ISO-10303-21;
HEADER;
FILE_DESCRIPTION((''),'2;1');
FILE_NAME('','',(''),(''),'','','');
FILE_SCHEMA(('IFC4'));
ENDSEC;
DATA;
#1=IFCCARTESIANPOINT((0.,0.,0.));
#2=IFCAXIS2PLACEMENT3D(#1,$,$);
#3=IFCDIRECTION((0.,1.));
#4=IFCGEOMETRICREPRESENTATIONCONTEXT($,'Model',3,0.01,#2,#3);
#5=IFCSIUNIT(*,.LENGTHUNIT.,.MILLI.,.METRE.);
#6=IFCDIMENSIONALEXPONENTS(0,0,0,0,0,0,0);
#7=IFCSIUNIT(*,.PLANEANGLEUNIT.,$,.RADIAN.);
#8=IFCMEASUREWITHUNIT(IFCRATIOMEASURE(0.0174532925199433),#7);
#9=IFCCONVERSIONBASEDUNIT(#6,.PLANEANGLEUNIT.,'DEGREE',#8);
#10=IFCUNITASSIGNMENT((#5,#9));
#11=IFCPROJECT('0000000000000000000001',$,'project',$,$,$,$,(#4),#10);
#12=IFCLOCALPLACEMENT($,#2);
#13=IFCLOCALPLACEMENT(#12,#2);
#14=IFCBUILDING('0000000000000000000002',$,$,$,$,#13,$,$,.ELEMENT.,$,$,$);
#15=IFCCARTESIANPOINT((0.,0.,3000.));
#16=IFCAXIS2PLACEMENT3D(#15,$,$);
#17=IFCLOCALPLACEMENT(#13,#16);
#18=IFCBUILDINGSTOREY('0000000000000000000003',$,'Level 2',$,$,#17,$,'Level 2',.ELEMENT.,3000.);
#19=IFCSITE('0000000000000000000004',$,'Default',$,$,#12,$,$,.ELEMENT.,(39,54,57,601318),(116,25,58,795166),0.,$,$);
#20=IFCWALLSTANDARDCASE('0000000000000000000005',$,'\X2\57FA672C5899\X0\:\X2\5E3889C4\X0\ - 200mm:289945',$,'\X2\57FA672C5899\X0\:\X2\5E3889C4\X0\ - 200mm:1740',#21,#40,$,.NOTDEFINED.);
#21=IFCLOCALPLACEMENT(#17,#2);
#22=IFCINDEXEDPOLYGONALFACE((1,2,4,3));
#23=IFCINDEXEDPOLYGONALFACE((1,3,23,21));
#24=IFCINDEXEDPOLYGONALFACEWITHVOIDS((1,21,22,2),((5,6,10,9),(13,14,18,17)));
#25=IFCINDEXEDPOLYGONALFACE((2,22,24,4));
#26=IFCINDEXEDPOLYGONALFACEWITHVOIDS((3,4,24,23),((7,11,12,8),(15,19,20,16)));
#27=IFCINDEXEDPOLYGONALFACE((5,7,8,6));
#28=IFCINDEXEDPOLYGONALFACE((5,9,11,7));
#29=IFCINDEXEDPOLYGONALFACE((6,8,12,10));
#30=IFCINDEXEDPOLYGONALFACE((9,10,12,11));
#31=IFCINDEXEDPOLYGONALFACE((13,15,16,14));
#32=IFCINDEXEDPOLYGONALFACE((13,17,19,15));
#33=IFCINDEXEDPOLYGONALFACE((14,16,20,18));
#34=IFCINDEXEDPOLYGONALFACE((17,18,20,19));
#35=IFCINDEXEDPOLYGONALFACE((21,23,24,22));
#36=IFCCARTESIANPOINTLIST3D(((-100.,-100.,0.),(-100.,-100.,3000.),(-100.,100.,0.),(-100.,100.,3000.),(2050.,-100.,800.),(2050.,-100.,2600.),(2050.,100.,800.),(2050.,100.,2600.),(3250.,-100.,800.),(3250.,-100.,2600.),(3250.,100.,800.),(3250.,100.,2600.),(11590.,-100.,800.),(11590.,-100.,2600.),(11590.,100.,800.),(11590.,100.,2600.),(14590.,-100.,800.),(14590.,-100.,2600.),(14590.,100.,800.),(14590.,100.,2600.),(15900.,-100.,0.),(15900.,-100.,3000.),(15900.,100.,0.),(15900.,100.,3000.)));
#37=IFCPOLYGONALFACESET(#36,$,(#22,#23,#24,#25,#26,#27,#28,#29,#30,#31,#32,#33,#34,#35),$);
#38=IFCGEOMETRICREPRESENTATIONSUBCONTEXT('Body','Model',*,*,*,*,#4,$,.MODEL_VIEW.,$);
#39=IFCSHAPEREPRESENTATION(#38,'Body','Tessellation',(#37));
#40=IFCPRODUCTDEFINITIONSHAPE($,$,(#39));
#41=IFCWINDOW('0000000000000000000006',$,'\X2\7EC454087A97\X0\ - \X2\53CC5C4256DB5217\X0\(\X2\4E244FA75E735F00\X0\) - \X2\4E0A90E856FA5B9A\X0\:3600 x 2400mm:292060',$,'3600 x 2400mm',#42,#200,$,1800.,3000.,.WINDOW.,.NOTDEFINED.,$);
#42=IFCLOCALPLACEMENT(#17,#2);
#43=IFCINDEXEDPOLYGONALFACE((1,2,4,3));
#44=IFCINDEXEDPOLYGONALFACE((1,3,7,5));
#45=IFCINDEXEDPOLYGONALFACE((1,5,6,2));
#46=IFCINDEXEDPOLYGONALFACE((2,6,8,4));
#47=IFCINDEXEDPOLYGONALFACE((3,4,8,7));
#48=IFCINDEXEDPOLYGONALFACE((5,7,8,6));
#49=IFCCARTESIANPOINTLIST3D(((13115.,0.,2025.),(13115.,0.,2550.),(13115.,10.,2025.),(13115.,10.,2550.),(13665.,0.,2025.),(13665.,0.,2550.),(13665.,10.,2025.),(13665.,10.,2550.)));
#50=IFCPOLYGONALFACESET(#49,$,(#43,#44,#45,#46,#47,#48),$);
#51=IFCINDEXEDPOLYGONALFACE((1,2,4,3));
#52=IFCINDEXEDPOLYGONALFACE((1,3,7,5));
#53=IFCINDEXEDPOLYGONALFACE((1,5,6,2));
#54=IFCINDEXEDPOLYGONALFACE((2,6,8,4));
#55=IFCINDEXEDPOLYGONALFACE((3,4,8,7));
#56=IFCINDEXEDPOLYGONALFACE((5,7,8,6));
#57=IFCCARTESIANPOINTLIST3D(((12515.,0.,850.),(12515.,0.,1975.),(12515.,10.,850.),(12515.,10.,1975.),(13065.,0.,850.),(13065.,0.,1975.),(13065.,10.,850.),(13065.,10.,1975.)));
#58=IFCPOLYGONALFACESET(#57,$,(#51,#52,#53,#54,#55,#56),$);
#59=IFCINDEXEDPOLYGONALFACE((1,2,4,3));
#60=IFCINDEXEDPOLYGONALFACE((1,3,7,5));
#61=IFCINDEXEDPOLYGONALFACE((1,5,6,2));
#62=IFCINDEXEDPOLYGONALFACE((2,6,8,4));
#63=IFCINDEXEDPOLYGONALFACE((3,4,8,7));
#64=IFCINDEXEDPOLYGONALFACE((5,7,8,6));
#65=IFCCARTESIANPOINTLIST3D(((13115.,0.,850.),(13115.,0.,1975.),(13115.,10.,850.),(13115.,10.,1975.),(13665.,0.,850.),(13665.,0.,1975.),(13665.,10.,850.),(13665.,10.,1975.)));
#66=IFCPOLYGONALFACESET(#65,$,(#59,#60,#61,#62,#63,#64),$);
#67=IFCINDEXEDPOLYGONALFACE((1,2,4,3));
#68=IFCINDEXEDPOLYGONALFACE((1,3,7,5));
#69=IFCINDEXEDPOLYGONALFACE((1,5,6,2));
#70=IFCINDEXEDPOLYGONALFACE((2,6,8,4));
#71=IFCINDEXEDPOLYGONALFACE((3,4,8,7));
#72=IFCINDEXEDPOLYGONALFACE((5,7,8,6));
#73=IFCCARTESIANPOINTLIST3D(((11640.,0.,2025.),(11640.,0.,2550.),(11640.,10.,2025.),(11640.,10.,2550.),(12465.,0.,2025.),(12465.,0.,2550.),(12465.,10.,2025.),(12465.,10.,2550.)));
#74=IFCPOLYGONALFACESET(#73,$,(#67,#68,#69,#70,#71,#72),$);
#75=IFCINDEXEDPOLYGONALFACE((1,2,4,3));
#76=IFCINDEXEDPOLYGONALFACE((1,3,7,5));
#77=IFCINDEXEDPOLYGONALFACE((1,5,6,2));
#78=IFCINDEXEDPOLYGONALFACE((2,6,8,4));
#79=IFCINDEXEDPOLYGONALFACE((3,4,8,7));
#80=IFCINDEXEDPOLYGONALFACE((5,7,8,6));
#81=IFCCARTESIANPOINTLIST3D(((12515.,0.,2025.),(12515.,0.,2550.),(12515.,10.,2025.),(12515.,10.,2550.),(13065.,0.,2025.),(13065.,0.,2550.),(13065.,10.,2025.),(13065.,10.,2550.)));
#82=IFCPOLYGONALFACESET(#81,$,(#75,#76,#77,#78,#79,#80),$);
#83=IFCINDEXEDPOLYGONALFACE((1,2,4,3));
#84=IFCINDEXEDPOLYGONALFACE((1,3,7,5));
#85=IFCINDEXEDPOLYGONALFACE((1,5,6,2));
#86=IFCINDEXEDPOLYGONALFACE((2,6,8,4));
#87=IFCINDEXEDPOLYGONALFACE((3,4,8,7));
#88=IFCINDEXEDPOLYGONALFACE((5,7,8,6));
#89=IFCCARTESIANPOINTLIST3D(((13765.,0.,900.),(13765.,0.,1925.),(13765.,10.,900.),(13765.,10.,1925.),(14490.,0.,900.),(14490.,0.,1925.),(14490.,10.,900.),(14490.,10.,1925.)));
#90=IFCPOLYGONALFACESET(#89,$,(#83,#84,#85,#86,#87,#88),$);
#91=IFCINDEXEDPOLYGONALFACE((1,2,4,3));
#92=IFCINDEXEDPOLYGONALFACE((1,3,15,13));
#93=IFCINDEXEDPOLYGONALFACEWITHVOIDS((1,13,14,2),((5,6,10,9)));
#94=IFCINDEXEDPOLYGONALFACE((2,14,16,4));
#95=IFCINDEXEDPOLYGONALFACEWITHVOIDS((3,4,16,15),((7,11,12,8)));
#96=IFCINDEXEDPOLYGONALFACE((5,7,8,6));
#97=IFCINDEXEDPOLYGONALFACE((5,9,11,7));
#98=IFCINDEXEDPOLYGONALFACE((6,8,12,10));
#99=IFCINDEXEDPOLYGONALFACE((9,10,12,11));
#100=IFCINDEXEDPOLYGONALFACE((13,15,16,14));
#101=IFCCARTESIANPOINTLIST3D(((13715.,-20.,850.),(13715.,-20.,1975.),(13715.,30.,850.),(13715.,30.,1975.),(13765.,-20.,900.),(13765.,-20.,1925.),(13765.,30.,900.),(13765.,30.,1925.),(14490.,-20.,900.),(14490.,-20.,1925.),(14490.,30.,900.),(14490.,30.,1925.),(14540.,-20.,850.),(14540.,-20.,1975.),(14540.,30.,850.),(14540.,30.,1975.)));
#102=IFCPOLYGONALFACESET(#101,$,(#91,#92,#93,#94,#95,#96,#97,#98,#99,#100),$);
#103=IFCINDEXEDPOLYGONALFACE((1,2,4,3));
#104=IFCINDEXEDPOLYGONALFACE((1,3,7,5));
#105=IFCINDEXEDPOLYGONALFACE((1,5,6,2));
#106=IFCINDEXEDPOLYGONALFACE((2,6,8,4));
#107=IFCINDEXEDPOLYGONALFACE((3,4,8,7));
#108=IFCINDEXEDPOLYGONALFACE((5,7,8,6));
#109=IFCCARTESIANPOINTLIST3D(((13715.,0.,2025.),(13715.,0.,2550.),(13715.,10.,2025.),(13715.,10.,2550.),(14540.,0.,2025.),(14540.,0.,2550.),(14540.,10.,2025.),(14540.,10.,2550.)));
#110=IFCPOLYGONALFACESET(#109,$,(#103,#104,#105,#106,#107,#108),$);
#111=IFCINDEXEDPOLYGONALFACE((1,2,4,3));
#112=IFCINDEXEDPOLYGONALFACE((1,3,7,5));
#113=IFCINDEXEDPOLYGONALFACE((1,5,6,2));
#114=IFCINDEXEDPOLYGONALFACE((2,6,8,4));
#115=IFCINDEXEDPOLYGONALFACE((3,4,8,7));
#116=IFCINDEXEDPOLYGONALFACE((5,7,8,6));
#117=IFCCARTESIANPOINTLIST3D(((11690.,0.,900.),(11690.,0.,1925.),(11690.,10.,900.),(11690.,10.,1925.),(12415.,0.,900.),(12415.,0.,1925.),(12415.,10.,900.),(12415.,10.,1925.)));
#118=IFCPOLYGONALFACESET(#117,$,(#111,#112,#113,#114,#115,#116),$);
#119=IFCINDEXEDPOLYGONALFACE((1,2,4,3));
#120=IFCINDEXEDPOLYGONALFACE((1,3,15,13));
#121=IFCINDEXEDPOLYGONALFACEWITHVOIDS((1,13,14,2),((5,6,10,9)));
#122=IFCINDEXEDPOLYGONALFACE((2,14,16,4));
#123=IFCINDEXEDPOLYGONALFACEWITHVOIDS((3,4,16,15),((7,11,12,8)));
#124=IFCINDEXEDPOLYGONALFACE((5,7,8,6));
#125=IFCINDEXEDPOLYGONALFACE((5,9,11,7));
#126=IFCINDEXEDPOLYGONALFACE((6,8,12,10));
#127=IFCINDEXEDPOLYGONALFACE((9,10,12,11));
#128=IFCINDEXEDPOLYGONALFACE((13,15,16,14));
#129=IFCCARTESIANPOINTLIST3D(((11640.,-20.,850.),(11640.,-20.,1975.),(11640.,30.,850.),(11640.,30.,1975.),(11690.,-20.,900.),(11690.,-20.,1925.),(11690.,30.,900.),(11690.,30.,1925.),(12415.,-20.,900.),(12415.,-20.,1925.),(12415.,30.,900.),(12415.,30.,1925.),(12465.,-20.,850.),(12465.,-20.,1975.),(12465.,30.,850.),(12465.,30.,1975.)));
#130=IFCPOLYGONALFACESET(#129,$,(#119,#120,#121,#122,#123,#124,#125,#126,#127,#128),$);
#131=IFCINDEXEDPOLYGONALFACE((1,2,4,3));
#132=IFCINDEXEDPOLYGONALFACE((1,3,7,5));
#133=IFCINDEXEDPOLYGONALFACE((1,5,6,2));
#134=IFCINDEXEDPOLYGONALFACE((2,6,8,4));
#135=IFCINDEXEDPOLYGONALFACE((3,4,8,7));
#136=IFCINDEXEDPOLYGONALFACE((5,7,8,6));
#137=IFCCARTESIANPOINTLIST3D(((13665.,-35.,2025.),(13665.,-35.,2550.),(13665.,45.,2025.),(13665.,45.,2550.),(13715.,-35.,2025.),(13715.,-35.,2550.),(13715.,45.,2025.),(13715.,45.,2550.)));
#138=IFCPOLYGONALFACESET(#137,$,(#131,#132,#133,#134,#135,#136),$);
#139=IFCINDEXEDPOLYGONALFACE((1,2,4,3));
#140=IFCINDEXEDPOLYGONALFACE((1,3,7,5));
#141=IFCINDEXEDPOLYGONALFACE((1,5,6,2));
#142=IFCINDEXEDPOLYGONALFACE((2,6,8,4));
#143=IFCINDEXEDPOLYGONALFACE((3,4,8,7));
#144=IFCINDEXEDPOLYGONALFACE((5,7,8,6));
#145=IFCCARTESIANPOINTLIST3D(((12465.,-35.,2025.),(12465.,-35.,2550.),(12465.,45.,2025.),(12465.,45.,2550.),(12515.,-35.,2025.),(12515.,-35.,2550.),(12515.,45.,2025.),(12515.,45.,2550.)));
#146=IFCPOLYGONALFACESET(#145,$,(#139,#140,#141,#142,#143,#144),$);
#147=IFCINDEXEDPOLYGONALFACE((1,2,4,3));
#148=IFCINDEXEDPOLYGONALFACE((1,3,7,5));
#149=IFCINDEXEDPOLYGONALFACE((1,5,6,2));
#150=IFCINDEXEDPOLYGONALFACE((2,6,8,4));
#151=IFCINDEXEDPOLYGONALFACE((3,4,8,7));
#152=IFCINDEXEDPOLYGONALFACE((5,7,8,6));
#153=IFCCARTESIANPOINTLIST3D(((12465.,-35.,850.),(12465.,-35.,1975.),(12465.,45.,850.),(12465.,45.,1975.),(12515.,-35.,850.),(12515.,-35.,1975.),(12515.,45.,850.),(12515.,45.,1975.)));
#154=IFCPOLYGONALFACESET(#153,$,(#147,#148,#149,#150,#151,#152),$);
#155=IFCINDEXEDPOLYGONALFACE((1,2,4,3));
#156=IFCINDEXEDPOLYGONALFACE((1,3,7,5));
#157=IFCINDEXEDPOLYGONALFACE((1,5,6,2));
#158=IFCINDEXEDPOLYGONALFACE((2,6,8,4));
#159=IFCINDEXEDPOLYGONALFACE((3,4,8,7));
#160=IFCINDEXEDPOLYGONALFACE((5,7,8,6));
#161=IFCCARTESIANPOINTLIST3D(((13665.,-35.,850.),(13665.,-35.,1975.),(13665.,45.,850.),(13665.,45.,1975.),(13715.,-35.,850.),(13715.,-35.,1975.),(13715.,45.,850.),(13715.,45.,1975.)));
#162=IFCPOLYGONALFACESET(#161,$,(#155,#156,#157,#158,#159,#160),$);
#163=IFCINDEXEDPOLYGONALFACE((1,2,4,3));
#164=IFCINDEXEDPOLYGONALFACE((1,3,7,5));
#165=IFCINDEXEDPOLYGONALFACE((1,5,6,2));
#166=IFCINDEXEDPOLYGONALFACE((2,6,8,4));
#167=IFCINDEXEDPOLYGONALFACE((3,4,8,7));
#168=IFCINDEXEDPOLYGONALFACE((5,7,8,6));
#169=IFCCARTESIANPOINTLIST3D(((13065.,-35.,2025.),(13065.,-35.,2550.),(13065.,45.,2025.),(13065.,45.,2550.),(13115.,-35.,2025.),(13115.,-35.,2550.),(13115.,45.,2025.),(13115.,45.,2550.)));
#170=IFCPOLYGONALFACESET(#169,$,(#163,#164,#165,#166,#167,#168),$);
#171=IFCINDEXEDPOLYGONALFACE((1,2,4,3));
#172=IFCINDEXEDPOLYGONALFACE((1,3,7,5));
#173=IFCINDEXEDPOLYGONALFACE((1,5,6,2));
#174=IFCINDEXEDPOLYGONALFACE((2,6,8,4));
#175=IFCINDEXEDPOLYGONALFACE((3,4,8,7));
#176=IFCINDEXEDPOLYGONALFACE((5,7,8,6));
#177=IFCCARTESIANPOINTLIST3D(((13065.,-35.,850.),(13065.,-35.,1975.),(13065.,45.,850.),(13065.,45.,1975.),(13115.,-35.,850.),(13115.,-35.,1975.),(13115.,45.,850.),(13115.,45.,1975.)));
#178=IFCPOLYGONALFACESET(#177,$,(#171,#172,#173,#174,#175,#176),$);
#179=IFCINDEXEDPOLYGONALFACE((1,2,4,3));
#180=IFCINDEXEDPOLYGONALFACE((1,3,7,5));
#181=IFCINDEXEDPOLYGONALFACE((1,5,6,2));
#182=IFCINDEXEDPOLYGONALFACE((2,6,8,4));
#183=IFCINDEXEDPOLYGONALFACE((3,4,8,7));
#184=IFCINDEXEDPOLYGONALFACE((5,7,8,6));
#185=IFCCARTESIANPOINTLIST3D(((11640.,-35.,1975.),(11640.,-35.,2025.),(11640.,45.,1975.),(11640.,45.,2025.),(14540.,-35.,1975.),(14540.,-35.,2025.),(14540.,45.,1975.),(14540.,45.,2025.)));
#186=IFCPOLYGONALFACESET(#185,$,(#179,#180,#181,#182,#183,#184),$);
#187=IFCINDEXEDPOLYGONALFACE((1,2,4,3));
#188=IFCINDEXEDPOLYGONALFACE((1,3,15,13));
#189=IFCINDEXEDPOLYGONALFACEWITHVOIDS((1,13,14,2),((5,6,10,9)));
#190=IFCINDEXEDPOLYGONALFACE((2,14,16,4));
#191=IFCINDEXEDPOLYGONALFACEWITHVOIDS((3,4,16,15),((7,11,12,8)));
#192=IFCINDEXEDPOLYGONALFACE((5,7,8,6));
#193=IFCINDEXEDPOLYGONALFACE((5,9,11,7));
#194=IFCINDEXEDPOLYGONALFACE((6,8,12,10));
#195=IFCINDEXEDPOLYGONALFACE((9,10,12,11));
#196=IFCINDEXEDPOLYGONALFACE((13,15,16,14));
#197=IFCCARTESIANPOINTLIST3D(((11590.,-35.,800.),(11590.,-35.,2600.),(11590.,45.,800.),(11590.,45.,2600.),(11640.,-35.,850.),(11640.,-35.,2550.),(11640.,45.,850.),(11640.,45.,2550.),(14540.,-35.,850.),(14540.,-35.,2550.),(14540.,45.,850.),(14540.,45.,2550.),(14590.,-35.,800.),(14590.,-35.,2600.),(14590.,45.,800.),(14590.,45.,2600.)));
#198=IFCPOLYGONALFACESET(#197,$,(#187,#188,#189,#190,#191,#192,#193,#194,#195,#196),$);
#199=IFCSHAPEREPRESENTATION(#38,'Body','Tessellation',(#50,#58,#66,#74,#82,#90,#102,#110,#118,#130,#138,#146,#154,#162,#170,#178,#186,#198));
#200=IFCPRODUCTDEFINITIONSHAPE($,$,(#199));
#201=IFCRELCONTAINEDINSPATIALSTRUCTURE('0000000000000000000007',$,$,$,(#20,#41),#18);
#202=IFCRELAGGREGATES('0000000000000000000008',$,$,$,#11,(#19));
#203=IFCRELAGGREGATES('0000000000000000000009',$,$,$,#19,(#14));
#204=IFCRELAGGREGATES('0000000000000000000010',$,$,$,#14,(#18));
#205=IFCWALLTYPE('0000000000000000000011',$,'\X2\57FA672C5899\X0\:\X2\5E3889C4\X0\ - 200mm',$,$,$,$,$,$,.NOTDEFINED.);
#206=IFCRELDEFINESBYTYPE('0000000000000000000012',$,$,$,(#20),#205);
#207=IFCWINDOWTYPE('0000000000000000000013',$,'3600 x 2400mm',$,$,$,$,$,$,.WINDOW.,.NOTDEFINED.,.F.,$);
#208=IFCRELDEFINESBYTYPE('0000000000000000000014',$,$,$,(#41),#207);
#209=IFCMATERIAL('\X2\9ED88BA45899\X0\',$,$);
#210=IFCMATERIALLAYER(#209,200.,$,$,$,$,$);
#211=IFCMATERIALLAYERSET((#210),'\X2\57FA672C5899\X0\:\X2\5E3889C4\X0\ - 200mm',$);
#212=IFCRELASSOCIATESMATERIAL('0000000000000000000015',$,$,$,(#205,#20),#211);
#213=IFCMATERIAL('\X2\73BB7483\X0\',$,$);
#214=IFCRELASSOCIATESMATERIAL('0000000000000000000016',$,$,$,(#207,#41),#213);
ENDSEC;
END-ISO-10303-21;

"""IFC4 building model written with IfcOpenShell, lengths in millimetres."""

from ifc_helpers import new_model, entity, si_unit, converted_unit, direction, frame, frame_2d, origin, origin_2d_with_axis, place, context, subcontext, project, spatial, polyline, rectangle, outline, extrude, source, transform, mapped, material, layer, layer_set, layer_usage, type_object, type_shapes, element, fill, save


model = new_model("IFC4")

# Units and contexts
model_context = context("Model", 3, precision=0.01, world=origin(), true_north=direction((0.0, 1.0)))
body_context = subcontext(model_context, "Body", "Model", "MODEL_VIEW")
ifc_project = project(units=[si_unit("LENGTHUNIT", "METRE", prefix="MILLI"), converted_unit("PLANEANGLEUNIT", "DEGREE", entity("IfcRatioMeasure", 0.0174532925199433), si_unit("PLANEANGLEUNIT", "RADIAN"), dimensions=[0, 0, 0, 0, 0, 0, 0])], contexts=[model_context])

# Site, building, storey
site_placement = place(None, origin())
site = spatial("IfcSite", under=ifc_project, at=site_placement, Name="Default", CompositionType="ELEMENT", RefLatitude=(39, 54, 57, 601318), RefLongitude=(116, 25, 58, 795166), RefElevation=0.0)
building_placement = place(site_placement, origin())
building = spatial("IfcBuilding", under=site, at=building_placement, CompositionType="ELEMENT")
storey_placement = place(building_placement, frame((0.0, 0.0, 3000.0)))
storey = spatial("IfcBuildingStorey", under=building, at=storey_placement, Name="Level 2", LongName="Level 2", CompositionType="ELEMENT", Elevation=3000.0)

# Shared definitions
ifc_material_1 = material(Name="默认墙")
ifc_layer = layer(ifc_material_1, 200.0)
ifc_layer_set = layer_set([ifc_layer], Name="基本墙:常规 - 200mm")
wall_type = type_object("IfcWallType", Name="基本墙:常规 - 200mm", PredefinedType="NOTDEFINED", material=ifc_layer_set)

# Shared definitions
ifc_material_2 = material(Name="玻璃")

# Wall, openings, window
ifc_layer_usage_1 = layer_usage(ifc_layer_set, "AXIS2", "NEGATIVE", 100.0)
wall_1_placement = place(storey_placement, frame((15900.0, 0.0, 0.0), z_axis=(0.0, 0.0, 1.0), x_axis=(-1.0, 0.0, 0.0)))
wall_1 = element("IfcWallStandardCase", 1, at=wall_1_placement, inside=storey, type_object=wall_type, material=ifc_layer_usage_1, Name="基本墙:常规 - 200mm:289945", ObjectType="基本墙:常规 - 200mm:1740", PredefinedType="NOTDEFINED", context=body_context, shape_type="SweptSolid", body=[
    extrude(rectangle(XDim=16000.0, YDim=200.0, at=frame_2d((8000.0, 0.0), x_axis=(-1.0, 0.0))), origin(), (0.0, 0.0, 1.0), 3000.0),
])
opening_1_placement = place(wall_1_placement, frame((12650.0, -100.0, 800.0)))
element("IfcOpeningElement", 2, at=opening_1_placement, cuts=wall_1, ObjectType="Opening", PredefinedType="OPENING", context=body_context, shape_type="SweptSolid", body=[
    extrude(rectangle(XDim=1800.0, YDim=1200.0, at=frame_2d((900.0, 600.0), x_axis=(1.0, 0.0))), frame((0.0, 0.0, 0.0), z_axis=(0.0, 1.0, 0.0), x_axis=(0.0, 0.0, 1.0)), (0.0, 0.0, 1.0), 200.0),
])
opening_2_placement = place(wall_1_placement, frame((1310.0, -100.0, 800.0)))
opening_2 = element("IfcOpeningElement", 3, at=opening_2_placement, cuts=wall_1, ObjectType="Opening", PredefinedType="OPENING", context=body_context, shape_type="SweptSolid", body=[
    extrude(rectangle(XDim=1800.0, YDim=3000.0, at=frame_2d((900.0, 1500.0), x_axis=(1.0, 0.0))), frame((0.0, 0.0, 0.0), z_axis=(0.0, 1.0, 0.0), x_axis=(0.0, 0.0, 1.0)), (0.0, 0.0, 1.0), 200.0),
])
window_type_1 = type_object("IfcWindowType", Name="3600 x 2400mm", ParameterTakesPrecedence=False, PartitioningType="NOTDEFINED", PredefinedType="WINDOW", material=ifc_material_2)
shared_shape_1 = source(origin(), body_context, "Body", "SweptSolid", [
    extrude(rectangle(XDim=10.0, YDim=550.0, at=origin_2d_with_axis()), frame((1200.0, 95.0, 1225.0), z_axis=(0.0, 0.0, 1.0), x_axis=(0.0, 1.0, 0.0)), (0.0, 0.0, 1.0), 525.0),
    extrude(rectangle(XDim=10.0, YDim=550.0, at=origin_2d_with_axis()), frame((1800.0, 95.0, 50.0), z_axis=(0.0, 0.0, 1.0), x_axis=(0.0, 1.0, 0.0)), (0.0, 0.0, 1.0), 1125.0),
    extrude(rectangle(XDim=10.0, YDim=550.0, at=origin_2d_with_axis()), frame((1200.0, 95.0, 50.0), z_axis=(0.0, 0.0, 1.0), x_axis=(0.0, 1.0, 0.0)), (0.0, 0.0, 1.0), 1125.0),
    extrude(rectangle(XDim=10.0, YDim=825.0, at=frame_2d((0.0, 0.0), x_axis=(1.0, 0.0))), frame((2537.5, 95.0, 1225.0), z_axis=(0.0, 0.0, 1.0), x_axis=(0.0, 1.0, 0.0)), (0.0, 0.0, 1.0), 525.0),
    extrude(rectangle(XDim=10.0, YDim=550.0, at=frame_2d((0.0, 0.0), x_axis=(1.0, 0.0))), frame((1800.0, 95.0, 1225.0), z_axis=(0.0, 0.0, 1.0), x_axis=(0.0, 1.0, 0.0)), (0.0, 0.0, 1.0), 525.0),
    extrude(rectangle(XDim=10.0, YDim=725.0, at=frame_2d((0.0, 0.0), x_axis=(1.0, 0.0))), frame((462.5, 95.0, 100.0), z_axis=(0.0, 0.0, 1.0), x_axis=(0.0, 1.0, 0.0)), (0.0, 0.0, 1.0), 1025.0),
    extrude(outline(polyline([(-562.5, -412.5), (562.5, -412.5), (562.5, 412.5), (-562.5, 412.5), (-562.5, -412.5)]), holes=[polyline([(512.5, -362.5), (-512.5, -362.5), (-512.5, 362.5), (512.5, 362.5), (512.5, -362.5)])]), frame((462.5, 70.0, 612.5), z_axis=(0.0, 1.0, 0.0), x_axis=(0.0, 0.0, -1.0)), (0.0, 0.0, 1.0), 50.0),
    extrude(rectangle(XDim=10.0, YDim=825.0, at=origin_2d_with_axis()), frame((462.5, 95.0, 1225.0), z_axis=(0.0, 0.0, 1.0), x_axis=(0.0, 1.0, 0.0)), (0.0, 0.0, 1.0), 525.0),
    extrude(rectangle(XDim=10.0, YDim=725.0, at=frame_2d((0.0, 0.0), x_axis=(1.0, 0.0))), frame((2537.5, 95.0, 100.0), z_axis=(0.0, 0.0, 1.0), x_axis=(0.0, 1.0, 0.0)), (0.0, 0.0, 1.0), 1025.0),
    extrude(outline(polyline([(-562.5, -412.5), (562.5, -412.5), (562.5, 412.5), (-562.5, 412.5), (-562.5, -412.5)]), holes=[polyline([(512.5, -362.5), (-512.5, -362.5), (-512.5, 362.5), (512.5, 362.5), (512.5, -362.5)])]), frame((2537.5, 70.0, 612.5), z_axis=(0.0, 1.0, 0.0), x_axis=(0.0, 0.0, -1.0)), (0.0, 0.0, 1.0), 50.0),
    extrude(rectangle(XDim=80.0, YDim=50.0, at=origin_2d_with_axis()), frame((900.0, 95.0, 1225.0), z_axis=(0.0, 0.0, 1.0), x_axis=(0.0, -1.0, 0.0)), (0.0, 0.0, 1.0), 525.0),
    extrude(rectangle(XDim=80.0, YDim=50.0, at=frame_2d((0.0, 0.0), x_axis=(1.0, 0.0))), frame((2100.0, 95.0, 1225.0), z_axis=(0.0, 0.0, 1.0), x_axis=(0.0, -1.0, 0.0)), (0.0, 0.0, 1.0), 525.0),
    extrude(rectangle(XDim=80.0, YDim=50.0, at=origin_2d_with_axis()), frame((2100.0, 95.0, 50.0), z_axis=(0.0, 0.0, 1.0), x_axis=(0.0, -1.0, 0.0)), (0.0, 0.0, 1.0), 1125.0),
    extrude(rectangle(XDim=80.0, YDim=50.0, at=origin_2d_with_axis()), frame((900.0, 95.0, 50.0), z_axis=(0.0, 0.0, 1.0), x_axis=(0.0, -1.0, 0.0)), (0.0, 0.0, 1.0), 1125.0),
    extrude(rectangle(XDim=80.0, YDim=50.0, at=frame_2d((0.0, 0.0), x_axis=(1.0, 0.0))), frame((1500.0, 95.0, 1225.0), z_axis=(0.0, 0.0, 1.0), x_axis=(0.0, -1.0, 0.0)), (0.0, 0.0, 1.0), 525.0),
    extrude(rectangle(XDim=80.0, YDim=50.0, at=origin_2d_with_axis()), frame((1500.0, 95.0, 50.0), z_axis=(0.0, 0.0, 1.0), x_axis=(0.0, -1.0, 0.0)), (0.0, 0.0, 1.0), 1125.0),
    extrude(rectangle(XDim=80.0, YDim=2900.0, at=frame_2d((0.0, 0.0), x_axis=(1.0, 0.0))), frame((1500.0, 95.0, 1175.0), z_axis=(0.0, 0.0, 1.0), x_axis=(0.0, -1.0, 0.0)), (0.0, 0.0, 1.0), 50.0),
    extrude(outline(polyline([(-1500.0, -900.0), (1500.0, -900.0), (1500.0, 900.0), (-1500.0, 900.0), (-1500.0, -900.0)]), holes=[polyline([(1450.0, -850.0), (-1450.0, -850.0), (-1450.0, 850.0), (1450.0, 850.0), (1450.0, -850.0)])]), frame((1500.0, 55.0, 900.0), z_axis=(0.0, 1.0, 0.0), x_axis=(1.0, 0.0, 0.0)), (0.0, 0.0, 1.0), 80.0),
])
type_shapes(window_type_1, [shared_shape_1])
window_1_placement = place(opening_2_placement, origin())
window_1 = element("IfcWindow", 4, at=window_1_placement, inside=storey, type_object=window_type_1, material=ifc_material_2, Name="组合窗 - 双层四列(两侧平开) - 上部固定:3600 x 2400mm:292060", ObjectType="3600 x 2400mm", OverallHeight=1800.0, OverallWidth=3000.0, PartitioningType="NOTDEFINED", PredefinedType="WINDOW", context=body_context, shape_type="MappedRepresentation", body=[
    mapped(shared_shape_1, transform((0.0, 0.0, 0.0), scale=1.0)),
])
fill(opening_2, window_1)

save(model, "model.ifc")
